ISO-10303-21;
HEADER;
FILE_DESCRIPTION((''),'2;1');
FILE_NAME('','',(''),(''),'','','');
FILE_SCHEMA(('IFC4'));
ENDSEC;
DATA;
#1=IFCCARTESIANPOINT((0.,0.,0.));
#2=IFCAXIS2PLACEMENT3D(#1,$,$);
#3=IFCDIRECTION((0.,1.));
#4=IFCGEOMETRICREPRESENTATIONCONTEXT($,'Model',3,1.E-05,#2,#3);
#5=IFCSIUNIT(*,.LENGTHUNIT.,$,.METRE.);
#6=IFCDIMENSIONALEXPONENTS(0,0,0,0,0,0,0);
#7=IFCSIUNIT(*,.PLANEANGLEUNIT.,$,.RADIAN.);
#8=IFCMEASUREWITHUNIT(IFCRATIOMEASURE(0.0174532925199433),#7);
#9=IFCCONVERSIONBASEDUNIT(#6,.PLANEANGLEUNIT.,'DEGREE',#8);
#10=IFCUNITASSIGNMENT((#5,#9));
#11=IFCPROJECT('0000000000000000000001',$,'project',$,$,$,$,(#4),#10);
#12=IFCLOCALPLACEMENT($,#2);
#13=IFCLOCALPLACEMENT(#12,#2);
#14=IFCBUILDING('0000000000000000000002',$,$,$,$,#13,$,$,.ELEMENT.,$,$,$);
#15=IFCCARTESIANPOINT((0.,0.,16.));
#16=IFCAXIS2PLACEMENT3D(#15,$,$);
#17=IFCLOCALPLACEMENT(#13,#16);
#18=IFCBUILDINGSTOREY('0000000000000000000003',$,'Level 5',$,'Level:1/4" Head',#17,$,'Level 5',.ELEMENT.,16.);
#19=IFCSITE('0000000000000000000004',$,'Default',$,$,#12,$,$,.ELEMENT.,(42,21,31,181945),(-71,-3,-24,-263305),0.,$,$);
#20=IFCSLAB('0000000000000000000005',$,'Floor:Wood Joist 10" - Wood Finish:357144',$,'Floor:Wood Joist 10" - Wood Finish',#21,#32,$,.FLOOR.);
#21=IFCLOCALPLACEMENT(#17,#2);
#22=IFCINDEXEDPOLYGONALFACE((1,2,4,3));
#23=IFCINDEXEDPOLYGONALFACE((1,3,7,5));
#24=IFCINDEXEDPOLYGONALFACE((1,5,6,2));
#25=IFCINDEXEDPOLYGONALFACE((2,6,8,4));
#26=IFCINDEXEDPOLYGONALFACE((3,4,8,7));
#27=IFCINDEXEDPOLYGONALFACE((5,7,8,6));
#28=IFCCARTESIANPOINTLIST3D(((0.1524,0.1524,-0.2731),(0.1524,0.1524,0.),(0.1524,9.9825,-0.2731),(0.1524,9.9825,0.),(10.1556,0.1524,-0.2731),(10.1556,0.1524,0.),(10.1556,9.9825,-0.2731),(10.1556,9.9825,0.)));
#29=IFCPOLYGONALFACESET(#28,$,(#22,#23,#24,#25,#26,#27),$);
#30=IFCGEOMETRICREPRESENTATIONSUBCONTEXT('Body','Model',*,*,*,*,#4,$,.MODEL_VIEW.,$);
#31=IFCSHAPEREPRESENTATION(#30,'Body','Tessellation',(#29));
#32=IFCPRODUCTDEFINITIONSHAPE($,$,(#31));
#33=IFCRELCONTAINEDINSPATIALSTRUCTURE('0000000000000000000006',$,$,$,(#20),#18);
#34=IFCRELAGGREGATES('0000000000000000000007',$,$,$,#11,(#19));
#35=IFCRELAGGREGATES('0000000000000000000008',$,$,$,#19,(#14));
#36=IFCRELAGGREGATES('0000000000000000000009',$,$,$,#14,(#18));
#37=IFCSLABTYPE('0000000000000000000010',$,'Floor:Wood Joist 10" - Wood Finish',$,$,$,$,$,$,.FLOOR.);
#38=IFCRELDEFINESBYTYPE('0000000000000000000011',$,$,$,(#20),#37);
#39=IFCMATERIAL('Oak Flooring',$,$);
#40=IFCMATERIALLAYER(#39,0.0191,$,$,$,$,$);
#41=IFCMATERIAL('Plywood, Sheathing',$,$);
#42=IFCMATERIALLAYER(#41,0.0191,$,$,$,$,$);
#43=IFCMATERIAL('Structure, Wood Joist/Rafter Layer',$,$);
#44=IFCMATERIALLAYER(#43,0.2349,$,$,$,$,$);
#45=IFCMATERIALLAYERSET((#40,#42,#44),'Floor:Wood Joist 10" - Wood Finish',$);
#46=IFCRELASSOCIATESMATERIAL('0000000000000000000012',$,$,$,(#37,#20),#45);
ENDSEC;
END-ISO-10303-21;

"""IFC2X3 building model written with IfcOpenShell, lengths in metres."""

from ifc_helpers import new_model, entity, si_unit, converted_unit, direction, frame, frame_2d, origin, place, context, subcontext, project, spatial, rectangle, extrude, material, layer, layer_set, layer_usage, type_object, element, save


model = new_model("IFC2X3")

# Units and contexts
model_context = context("Model", 3, precision=1e-05, world=origin(), true_north=direction((0.0, 1.0)))
body_context = subcontext(model_context, "Body", "Model", "MODEL_VIEW")
ifc_project = project(units=[si_unit("LENGTHUNIT", "METRE"), converted_unit("PLANEANGLEUNIT", "DEGREE", entity("IfcRatioMeasure", 0.0174532925199433), si_unit("PLANEANGLEUNIT", "RADIAN"), dimensions=[0, 0, 0, 0, 0, 0, 0])], contexts=[model_context])

# Site, building, storey
site_placement = place(None, origin())
site = spatial("IfcSite", under=ifc_project, at=site_placement, Name="Default", CompositionType="ELEMENT", RefLatitude=(42, 21, 31, 181945), RefLongitude=(-71, -3, -24, -263305), RefElevation=0.0)
building_placement = place(site_placement, origin())
building = spatial("IfcBuilding", under=site, at=building_placement, CompositionType="ELEMENT")
storey_placement = place(building_placement, frame((0.0, 0.0, 16.0)))
storey = spatial("IfcBuildingStorey", under=building, at=storey_placement, Name="Level 5", ObjectType="Level:1/4\" Head", LongName="Level 5", CompositionType="ELEMENT", Elevation=16.0)

# Slab
ifc_material_1 = material(Name="Oak Flooring")
ifc_layer_1 = layer(ifc_material_1, 0.0191)
ifc_material_2 = material(Name="Plywood, Sheathing")
ifc_layer_2 = layer(ifc_material_2, 0.0191)
ifc_material_3 = material(Name="Structure, Wood Joist/Rafter Layer")
ifc_layer_3 = layer(ifc_material_3, 0.2349)
ifc_layer_set = layer_set([ifc_layer_1, ifc_layer_2, ifc_layer_3], Name="Floor:Wood Joist 10\" - Wood Finish")
ifc_layer_usage = layer_usage(ifc_layer_set, "AXIS3", "POSITIVE", 0.0)
slab_type = type_object("IfcSlabType", Name="Floor:Wood Joist 10\" - Wood Finish", PredefinedType="FLOOR", material=ifc_layer_set)
slab_placement = place(storey_placement, origin())
element("IfcSlab", 1, at=slab_placement, inside=storey, type_object=slab_type, material=ifc_layer_usage, Name="Floor:Wood Joist 10\" - Wood Finish:357144", ObjectType="Floor:Wood Joist 10\" - Wood Finish", PredefinedType="FLOOR", context=body_context, shape_type="SweptSolid", body=[
    extrude(rectangle(XDim=9.8301, YDim=10.0032, at=frame_2d((0.0, 0.0), x_axis=(1.0, 0.0))), frame((5.154, 5.0675, 0.0), z_axis=(0.0, 0.0, -1.0), x_axis=(0.0, 1.0, 0.0)), (0.0, 0.0, 1.0), 0.2731),
])

save(model, "model.ifc")
